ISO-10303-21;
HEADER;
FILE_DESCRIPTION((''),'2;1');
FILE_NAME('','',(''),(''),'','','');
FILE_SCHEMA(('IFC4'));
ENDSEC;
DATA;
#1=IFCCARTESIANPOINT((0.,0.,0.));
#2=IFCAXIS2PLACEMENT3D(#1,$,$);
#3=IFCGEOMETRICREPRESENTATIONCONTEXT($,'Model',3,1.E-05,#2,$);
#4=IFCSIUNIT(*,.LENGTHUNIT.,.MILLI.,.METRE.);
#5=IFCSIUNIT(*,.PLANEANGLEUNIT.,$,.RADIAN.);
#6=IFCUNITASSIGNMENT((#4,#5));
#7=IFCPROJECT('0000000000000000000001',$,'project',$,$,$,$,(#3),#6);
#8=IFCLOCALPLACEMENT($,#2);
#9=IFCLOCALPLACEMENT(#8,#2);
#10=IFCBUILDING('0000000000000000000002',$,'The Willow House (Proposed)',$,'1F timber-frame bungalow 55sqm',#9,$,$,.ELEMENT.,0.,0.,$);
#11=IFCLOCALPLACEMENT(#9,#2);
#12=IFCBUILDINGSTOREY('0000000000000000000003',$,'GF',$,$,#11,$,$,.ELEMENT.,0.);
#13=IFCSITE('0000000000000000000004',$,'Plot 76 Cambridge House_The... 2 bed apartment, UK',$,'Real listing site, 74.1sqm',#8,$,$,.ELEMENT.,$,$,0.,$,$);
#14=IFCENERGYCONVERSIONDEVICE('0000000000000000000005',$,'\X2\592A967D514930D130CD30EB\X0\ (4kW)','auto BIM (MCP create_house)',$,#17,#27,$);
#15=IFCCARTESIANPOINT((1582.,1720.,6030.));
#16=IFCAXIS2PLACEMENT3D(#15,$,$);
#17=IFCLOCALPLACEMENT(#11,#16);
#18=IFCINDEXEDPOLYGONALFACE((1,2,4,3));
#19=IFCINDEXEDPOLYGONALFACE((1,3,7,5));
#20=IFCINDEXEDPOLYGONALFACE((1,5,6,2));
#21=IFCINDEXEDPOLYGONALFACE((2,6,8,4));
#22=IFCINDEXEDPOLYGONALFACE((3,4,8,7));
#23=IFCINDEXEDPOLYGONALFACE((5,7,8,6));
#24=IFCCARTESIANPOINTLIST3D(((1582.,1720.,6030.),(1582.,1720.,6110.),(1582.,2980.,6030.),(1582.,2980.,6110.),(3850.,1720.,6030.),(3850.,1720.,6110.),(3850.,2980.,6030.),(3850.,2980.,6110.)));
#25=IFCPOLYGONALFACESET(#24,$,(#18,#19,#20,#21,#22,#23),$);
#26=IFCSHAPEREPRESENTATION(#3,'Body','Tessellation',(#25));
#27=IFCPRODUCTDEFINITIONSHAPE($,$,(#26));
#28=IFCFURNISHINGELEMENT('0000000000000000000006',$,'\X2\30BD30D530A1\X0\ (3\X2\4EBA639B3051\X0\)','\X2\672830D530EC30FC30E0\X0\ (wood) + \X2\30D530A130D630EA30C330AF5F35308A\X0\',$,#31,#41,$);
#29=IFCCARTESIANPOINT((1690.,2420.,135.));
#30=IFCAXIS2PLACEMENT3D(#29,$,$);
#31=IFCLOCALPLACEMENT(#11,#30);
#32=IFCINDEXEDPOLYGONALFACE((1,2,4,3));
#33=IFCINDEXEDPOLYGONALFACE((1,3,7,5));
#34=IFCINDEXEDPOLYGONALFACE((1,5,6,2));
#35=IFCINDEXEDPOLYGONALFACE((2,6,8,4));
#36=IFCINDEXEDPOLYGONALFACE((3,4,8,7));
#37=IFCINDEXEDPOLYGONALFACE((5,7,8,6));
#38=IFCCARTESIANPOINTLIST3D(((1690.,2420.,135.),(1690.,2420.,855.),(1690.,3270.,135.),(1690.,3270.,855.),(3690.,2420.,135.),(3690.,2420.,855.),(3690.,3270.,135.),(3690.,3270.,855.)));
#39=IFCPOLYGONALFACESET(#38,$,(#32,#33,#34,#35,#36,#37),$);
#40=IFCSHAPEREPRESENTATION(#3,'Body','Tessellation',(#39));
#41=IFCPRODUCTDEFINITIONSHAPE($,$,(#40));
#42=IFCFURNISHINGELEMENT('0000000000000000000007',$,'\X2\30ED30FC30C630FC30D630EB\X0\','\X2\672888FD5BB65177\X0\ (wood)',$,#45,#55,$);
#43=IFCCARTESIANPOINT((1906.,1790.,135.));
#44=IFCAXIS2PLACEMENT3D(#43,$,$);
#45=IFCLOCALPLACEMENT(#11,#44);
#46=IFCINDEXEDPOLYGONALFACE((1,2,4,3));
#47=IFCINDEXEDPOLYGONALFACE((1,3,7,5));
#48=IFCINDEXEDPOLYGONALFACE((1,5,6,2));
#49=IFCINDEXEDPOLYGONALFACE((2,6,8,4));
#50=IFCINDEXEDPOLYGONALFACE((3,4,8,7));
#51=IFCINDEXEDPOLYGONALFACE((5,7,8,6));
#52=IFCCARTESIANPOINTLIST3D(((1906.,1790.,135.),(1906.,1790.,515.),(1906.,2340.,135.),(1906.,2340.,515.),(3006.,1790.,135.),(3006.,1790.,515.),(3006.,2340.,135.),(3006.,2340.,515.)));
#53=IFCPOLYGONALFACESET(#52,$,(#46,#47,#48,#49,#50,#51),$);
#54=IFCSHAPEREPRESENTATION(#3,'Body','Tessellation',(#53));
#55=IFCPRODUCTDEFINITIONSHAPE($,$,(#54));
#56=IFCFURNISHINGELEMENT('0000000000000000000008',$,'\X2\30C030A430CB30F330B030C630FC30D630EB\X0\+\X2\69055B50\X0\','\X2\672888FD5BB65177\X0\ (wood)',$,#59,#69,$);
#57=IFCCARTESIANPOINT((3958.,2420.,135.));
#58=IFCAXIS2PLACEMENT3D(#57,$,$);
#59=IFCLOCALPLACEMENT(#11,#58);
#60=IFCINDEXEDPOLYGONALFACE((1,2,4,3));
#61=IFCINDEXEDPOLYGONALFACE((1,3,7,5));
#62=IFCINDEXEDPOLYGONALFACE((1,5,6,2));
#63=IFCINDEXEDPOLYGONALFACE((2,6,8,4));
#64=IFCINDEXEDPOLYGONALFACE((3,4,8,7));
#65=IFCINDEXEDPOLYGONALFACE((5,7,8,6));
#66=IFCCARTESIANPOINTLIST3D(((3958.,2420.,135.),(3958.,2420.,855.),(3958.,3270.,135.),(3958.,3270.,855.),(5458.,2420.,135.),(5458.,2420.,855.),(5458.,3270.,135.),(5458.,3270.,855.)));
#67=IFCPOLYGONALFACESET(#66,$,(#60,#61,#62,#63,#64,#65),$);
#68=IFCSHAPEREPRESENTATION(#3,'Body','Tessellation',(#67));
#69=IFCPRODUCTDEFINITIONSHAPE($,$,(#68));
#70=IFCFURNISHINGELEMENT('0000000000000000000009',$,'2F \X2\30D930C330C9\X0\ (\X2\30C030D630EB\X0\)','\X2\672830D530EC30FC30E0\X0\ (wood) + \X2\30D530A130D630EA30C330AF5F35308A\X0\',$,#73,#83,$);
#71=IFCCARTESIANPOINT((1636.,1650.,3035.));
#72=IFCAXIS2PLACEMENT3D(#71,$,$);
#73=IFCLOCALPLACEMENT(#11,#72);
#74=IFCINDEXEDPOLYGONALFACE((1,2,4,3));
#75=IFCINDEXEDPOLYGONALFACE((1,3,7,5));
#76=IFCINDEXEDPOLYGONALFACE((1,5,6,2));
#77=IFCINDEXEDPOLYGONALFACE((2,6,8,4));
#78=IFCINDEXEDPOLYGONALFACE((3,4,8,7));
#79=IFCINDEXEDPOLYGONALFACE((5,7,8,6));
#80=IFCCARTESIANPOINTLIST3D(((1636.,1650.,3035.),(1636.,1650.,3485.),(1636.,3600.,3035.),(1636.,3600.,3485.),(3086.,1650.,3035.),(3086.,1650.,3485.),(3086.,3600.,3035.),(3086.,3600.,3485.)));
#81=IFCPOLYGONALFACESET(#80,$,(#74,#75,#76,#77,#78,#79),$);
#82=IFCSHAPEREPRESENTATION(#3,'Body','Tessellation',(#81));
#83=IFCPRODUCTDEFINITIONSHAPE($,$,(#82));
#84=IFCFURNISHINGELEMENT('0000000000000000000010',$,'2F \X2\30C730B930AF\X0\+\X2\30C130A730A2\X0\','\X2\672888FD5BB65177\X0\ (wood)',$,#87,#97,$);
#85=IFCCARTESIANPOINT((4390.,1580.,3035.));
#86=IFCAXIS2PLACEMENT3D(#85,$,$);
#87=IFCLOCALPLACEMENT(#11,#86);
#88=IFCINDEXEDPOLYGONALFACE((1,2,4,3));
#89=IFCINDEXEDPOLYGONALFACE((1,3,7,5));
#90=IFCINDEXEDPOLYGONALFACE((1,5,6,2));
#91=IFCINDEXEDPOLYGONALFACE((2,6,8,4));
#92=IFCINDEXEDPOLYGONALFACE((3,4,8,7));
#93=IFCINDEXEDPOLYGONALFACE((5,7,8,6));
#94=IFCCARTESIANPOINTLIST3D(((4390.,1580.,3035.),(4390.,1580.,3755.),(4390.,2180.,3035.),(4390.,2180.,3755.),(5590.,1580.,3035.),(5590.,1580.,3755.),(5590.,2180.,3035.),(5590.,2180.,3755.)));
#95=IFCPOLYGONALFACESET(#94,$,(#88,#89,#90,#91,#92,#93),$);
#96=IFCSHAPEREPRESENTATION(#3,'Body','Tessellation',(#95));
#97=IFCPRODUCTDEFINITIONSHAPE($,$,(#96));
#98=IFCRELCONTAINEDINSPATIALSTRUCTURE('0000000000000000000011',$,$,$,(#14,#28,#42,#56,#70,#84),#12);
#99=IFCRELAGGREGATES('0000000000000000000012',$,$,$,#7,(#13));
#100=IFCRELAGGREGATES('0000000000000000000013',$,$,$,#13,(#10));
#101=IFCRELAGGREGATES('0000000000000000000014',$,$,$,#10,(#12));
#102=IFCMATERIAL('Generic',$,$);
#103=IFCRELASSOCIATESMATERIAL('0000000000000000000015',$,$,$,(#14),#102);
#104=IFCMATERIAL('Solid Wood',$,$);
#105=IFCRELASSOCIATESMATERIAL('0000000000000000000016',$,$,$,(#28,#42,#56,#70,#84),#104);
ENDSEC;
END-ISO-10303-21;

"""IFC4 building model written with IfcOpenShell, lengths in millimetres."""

from ifc_helpers import new_model, si_unit, frame, frame_2d, origin, place, context, project, spatial, rectangle, extrude, material, element, save


model = new_model("IFC4")

# Units and contexts
model_context = context("Model", 3, precision=1e-05, world=origin())
ifc_project = project(units=[si_unit("LENGTHUNIT", "METRE", prefix="MILLI"), si_unit("PLANEANGLEUNIT", "RADIAN")], contexts=[model_context])

# Site, building, storey
site_placement = place(None, origin())
site = spatial("IfcSite", under=ifc_project, at=site_placement, Name="Plot 76 Cambridge House_The... 2 bed apartment, UK", ObjectType="Real listing site, 74.1sqm", CompositionType="ELEMENT", RefElevation=0.0)
building_placement = place(site_placement, origin())
building = spatial("IfcBuilding", under=site, at=building_placement, Name="The Willow House (Proposed)", ObjectType="1F timber-frame bungalow 55sqm", CompositionType="ELEMENT", ElevationOfRefHeight=0.0, ElevationOfTerrain=0.0)
storey_placement = place(building_placement, origin())
storey = spatial("IfcBuildingStorey", under=building, at=storey_placement, Name="GF", CompositionType="ELEMENT", Elevation=0.0)

# Shared definitions
ifc_material_1 = material(Name="Solid Wood")

# Shared definitions
ifc_material_2 = material(Name="Generic")

# Energy conversion device
energy_conversion_device_placement = place(storey_placement, frame((1582.0, 1720.0, 6030.0)))
element("IfcEnergyConversionDevice", 1, at=energy_conversion_device_placement, inside=storey, material=ifc_material_2, Name="太陽光パネル (4kW)", Description="auto BIM (MCP create_house)", context=model_context, shape_type="SweptSolid", body=[
    extrude(rectangle(XDim=2268.0, YDim=1260.0, at=frame_2d((1134.0, 630.0))), frame((1582.0, 1720.0, 6030.0)), (0.0, 0.0, 1.0), 80.0),
])

# Furnishing elements
furnishing_1_placement = place(storey_placement, frame((1690.0, 2420.0, 135.0)))
element("IfcFurnishingElement", 2, at=furnishing_1_placement, inside=storey, material=ifc_material_1, Name="ソファ (3人掛け)", Description="木フレーム (wood) + ファブリック張り", context=model_context, shape_type="SweptSolid", body=[
    extrude(rectangle(XDim=2000.0, YDim=850.0, at=frame_2d((1000.0, 425.0))), frame((1690.0, 2420.0, 135.0)), (0.0, 0.0, 1.0), 720.0),
])
furnishing_2_placement = place(storey_placement, frame((1906.0, 1790.0, 135.0)))
element("IfcFurnishingElement", 3, at=furnishing_2_placement, inside=storey, material=ifc_material_1, Name="ローテーブル", Description="木製家具 (wood)", context=model_context, shape_type="SweptSolid", body=[
    extrude(rectangle(XDim=1100.0, YDim=550.0, at=frame_2d((550.0, 275.0))), frame((1906.0, 1790.0, 135.0)), (0.0, 0.0, 1.0), 380.0),
])
furnishing_3_placement = place(storey_placement, frame((3958.0, 2420.0, 135.0)))
element("IfcFurnishingElement", 4, at=furnishing_3_placement, inside=storey, material=ifc_material_1, Name="ダイニングテーブル+椅子", Description="木製家具 (wood)", context=model_context, shape_type="SweptSolid", body=[
    extrude(rectangle(XDim=1500.0, YDim=850.0, at=frame_2d((750.0, 425.0))), frame((3958.0, 2420.0, 135.0)), (0.0, 0.0, 1.0), 720.0),
])
furnishing_4_placement = place(storey_placement, frame((1636.0, 1650.0, 3035.0)))
element("IfcFurnishingElement", 5, at=furnishing_4_placement, inside=storey, material=ifc_material_1, Name="2F ベッド (ダブル)", Description="木フレーム (wood) + ファブリック張り", context=model_context, shape_type="SweptSolid", body=[
    extrude(rectangle(XDim=1450.0, YDim=1950.0, at=frame_2d((725.0, 975.0))), frame((1636.0, 1650.0, 3035.0)), (0.0, 0.0, 1.0), 450.0),
])
furnishing_5_placement = place(storey_placement, frame((4390.0, 1580.0, 3035.0)))
element("IfcFurnishingElement", 6, at=furnishing_5_placement, inside=storey, material=ifc_material_1, Name="2F デスク+チェア", Description="木製家具 (wood)", context=model_context, shape_type="SweptSolid", body=[
    extrude(rectangle(XDim=1200.0, YDim=600.0, at=frame_2d((600.0, 300.0))), frame((4390.0, 1580.0, 3035.0)), (0.0, 0.0, 1.0), 720.0),
])

save(model, "model.ifc")
